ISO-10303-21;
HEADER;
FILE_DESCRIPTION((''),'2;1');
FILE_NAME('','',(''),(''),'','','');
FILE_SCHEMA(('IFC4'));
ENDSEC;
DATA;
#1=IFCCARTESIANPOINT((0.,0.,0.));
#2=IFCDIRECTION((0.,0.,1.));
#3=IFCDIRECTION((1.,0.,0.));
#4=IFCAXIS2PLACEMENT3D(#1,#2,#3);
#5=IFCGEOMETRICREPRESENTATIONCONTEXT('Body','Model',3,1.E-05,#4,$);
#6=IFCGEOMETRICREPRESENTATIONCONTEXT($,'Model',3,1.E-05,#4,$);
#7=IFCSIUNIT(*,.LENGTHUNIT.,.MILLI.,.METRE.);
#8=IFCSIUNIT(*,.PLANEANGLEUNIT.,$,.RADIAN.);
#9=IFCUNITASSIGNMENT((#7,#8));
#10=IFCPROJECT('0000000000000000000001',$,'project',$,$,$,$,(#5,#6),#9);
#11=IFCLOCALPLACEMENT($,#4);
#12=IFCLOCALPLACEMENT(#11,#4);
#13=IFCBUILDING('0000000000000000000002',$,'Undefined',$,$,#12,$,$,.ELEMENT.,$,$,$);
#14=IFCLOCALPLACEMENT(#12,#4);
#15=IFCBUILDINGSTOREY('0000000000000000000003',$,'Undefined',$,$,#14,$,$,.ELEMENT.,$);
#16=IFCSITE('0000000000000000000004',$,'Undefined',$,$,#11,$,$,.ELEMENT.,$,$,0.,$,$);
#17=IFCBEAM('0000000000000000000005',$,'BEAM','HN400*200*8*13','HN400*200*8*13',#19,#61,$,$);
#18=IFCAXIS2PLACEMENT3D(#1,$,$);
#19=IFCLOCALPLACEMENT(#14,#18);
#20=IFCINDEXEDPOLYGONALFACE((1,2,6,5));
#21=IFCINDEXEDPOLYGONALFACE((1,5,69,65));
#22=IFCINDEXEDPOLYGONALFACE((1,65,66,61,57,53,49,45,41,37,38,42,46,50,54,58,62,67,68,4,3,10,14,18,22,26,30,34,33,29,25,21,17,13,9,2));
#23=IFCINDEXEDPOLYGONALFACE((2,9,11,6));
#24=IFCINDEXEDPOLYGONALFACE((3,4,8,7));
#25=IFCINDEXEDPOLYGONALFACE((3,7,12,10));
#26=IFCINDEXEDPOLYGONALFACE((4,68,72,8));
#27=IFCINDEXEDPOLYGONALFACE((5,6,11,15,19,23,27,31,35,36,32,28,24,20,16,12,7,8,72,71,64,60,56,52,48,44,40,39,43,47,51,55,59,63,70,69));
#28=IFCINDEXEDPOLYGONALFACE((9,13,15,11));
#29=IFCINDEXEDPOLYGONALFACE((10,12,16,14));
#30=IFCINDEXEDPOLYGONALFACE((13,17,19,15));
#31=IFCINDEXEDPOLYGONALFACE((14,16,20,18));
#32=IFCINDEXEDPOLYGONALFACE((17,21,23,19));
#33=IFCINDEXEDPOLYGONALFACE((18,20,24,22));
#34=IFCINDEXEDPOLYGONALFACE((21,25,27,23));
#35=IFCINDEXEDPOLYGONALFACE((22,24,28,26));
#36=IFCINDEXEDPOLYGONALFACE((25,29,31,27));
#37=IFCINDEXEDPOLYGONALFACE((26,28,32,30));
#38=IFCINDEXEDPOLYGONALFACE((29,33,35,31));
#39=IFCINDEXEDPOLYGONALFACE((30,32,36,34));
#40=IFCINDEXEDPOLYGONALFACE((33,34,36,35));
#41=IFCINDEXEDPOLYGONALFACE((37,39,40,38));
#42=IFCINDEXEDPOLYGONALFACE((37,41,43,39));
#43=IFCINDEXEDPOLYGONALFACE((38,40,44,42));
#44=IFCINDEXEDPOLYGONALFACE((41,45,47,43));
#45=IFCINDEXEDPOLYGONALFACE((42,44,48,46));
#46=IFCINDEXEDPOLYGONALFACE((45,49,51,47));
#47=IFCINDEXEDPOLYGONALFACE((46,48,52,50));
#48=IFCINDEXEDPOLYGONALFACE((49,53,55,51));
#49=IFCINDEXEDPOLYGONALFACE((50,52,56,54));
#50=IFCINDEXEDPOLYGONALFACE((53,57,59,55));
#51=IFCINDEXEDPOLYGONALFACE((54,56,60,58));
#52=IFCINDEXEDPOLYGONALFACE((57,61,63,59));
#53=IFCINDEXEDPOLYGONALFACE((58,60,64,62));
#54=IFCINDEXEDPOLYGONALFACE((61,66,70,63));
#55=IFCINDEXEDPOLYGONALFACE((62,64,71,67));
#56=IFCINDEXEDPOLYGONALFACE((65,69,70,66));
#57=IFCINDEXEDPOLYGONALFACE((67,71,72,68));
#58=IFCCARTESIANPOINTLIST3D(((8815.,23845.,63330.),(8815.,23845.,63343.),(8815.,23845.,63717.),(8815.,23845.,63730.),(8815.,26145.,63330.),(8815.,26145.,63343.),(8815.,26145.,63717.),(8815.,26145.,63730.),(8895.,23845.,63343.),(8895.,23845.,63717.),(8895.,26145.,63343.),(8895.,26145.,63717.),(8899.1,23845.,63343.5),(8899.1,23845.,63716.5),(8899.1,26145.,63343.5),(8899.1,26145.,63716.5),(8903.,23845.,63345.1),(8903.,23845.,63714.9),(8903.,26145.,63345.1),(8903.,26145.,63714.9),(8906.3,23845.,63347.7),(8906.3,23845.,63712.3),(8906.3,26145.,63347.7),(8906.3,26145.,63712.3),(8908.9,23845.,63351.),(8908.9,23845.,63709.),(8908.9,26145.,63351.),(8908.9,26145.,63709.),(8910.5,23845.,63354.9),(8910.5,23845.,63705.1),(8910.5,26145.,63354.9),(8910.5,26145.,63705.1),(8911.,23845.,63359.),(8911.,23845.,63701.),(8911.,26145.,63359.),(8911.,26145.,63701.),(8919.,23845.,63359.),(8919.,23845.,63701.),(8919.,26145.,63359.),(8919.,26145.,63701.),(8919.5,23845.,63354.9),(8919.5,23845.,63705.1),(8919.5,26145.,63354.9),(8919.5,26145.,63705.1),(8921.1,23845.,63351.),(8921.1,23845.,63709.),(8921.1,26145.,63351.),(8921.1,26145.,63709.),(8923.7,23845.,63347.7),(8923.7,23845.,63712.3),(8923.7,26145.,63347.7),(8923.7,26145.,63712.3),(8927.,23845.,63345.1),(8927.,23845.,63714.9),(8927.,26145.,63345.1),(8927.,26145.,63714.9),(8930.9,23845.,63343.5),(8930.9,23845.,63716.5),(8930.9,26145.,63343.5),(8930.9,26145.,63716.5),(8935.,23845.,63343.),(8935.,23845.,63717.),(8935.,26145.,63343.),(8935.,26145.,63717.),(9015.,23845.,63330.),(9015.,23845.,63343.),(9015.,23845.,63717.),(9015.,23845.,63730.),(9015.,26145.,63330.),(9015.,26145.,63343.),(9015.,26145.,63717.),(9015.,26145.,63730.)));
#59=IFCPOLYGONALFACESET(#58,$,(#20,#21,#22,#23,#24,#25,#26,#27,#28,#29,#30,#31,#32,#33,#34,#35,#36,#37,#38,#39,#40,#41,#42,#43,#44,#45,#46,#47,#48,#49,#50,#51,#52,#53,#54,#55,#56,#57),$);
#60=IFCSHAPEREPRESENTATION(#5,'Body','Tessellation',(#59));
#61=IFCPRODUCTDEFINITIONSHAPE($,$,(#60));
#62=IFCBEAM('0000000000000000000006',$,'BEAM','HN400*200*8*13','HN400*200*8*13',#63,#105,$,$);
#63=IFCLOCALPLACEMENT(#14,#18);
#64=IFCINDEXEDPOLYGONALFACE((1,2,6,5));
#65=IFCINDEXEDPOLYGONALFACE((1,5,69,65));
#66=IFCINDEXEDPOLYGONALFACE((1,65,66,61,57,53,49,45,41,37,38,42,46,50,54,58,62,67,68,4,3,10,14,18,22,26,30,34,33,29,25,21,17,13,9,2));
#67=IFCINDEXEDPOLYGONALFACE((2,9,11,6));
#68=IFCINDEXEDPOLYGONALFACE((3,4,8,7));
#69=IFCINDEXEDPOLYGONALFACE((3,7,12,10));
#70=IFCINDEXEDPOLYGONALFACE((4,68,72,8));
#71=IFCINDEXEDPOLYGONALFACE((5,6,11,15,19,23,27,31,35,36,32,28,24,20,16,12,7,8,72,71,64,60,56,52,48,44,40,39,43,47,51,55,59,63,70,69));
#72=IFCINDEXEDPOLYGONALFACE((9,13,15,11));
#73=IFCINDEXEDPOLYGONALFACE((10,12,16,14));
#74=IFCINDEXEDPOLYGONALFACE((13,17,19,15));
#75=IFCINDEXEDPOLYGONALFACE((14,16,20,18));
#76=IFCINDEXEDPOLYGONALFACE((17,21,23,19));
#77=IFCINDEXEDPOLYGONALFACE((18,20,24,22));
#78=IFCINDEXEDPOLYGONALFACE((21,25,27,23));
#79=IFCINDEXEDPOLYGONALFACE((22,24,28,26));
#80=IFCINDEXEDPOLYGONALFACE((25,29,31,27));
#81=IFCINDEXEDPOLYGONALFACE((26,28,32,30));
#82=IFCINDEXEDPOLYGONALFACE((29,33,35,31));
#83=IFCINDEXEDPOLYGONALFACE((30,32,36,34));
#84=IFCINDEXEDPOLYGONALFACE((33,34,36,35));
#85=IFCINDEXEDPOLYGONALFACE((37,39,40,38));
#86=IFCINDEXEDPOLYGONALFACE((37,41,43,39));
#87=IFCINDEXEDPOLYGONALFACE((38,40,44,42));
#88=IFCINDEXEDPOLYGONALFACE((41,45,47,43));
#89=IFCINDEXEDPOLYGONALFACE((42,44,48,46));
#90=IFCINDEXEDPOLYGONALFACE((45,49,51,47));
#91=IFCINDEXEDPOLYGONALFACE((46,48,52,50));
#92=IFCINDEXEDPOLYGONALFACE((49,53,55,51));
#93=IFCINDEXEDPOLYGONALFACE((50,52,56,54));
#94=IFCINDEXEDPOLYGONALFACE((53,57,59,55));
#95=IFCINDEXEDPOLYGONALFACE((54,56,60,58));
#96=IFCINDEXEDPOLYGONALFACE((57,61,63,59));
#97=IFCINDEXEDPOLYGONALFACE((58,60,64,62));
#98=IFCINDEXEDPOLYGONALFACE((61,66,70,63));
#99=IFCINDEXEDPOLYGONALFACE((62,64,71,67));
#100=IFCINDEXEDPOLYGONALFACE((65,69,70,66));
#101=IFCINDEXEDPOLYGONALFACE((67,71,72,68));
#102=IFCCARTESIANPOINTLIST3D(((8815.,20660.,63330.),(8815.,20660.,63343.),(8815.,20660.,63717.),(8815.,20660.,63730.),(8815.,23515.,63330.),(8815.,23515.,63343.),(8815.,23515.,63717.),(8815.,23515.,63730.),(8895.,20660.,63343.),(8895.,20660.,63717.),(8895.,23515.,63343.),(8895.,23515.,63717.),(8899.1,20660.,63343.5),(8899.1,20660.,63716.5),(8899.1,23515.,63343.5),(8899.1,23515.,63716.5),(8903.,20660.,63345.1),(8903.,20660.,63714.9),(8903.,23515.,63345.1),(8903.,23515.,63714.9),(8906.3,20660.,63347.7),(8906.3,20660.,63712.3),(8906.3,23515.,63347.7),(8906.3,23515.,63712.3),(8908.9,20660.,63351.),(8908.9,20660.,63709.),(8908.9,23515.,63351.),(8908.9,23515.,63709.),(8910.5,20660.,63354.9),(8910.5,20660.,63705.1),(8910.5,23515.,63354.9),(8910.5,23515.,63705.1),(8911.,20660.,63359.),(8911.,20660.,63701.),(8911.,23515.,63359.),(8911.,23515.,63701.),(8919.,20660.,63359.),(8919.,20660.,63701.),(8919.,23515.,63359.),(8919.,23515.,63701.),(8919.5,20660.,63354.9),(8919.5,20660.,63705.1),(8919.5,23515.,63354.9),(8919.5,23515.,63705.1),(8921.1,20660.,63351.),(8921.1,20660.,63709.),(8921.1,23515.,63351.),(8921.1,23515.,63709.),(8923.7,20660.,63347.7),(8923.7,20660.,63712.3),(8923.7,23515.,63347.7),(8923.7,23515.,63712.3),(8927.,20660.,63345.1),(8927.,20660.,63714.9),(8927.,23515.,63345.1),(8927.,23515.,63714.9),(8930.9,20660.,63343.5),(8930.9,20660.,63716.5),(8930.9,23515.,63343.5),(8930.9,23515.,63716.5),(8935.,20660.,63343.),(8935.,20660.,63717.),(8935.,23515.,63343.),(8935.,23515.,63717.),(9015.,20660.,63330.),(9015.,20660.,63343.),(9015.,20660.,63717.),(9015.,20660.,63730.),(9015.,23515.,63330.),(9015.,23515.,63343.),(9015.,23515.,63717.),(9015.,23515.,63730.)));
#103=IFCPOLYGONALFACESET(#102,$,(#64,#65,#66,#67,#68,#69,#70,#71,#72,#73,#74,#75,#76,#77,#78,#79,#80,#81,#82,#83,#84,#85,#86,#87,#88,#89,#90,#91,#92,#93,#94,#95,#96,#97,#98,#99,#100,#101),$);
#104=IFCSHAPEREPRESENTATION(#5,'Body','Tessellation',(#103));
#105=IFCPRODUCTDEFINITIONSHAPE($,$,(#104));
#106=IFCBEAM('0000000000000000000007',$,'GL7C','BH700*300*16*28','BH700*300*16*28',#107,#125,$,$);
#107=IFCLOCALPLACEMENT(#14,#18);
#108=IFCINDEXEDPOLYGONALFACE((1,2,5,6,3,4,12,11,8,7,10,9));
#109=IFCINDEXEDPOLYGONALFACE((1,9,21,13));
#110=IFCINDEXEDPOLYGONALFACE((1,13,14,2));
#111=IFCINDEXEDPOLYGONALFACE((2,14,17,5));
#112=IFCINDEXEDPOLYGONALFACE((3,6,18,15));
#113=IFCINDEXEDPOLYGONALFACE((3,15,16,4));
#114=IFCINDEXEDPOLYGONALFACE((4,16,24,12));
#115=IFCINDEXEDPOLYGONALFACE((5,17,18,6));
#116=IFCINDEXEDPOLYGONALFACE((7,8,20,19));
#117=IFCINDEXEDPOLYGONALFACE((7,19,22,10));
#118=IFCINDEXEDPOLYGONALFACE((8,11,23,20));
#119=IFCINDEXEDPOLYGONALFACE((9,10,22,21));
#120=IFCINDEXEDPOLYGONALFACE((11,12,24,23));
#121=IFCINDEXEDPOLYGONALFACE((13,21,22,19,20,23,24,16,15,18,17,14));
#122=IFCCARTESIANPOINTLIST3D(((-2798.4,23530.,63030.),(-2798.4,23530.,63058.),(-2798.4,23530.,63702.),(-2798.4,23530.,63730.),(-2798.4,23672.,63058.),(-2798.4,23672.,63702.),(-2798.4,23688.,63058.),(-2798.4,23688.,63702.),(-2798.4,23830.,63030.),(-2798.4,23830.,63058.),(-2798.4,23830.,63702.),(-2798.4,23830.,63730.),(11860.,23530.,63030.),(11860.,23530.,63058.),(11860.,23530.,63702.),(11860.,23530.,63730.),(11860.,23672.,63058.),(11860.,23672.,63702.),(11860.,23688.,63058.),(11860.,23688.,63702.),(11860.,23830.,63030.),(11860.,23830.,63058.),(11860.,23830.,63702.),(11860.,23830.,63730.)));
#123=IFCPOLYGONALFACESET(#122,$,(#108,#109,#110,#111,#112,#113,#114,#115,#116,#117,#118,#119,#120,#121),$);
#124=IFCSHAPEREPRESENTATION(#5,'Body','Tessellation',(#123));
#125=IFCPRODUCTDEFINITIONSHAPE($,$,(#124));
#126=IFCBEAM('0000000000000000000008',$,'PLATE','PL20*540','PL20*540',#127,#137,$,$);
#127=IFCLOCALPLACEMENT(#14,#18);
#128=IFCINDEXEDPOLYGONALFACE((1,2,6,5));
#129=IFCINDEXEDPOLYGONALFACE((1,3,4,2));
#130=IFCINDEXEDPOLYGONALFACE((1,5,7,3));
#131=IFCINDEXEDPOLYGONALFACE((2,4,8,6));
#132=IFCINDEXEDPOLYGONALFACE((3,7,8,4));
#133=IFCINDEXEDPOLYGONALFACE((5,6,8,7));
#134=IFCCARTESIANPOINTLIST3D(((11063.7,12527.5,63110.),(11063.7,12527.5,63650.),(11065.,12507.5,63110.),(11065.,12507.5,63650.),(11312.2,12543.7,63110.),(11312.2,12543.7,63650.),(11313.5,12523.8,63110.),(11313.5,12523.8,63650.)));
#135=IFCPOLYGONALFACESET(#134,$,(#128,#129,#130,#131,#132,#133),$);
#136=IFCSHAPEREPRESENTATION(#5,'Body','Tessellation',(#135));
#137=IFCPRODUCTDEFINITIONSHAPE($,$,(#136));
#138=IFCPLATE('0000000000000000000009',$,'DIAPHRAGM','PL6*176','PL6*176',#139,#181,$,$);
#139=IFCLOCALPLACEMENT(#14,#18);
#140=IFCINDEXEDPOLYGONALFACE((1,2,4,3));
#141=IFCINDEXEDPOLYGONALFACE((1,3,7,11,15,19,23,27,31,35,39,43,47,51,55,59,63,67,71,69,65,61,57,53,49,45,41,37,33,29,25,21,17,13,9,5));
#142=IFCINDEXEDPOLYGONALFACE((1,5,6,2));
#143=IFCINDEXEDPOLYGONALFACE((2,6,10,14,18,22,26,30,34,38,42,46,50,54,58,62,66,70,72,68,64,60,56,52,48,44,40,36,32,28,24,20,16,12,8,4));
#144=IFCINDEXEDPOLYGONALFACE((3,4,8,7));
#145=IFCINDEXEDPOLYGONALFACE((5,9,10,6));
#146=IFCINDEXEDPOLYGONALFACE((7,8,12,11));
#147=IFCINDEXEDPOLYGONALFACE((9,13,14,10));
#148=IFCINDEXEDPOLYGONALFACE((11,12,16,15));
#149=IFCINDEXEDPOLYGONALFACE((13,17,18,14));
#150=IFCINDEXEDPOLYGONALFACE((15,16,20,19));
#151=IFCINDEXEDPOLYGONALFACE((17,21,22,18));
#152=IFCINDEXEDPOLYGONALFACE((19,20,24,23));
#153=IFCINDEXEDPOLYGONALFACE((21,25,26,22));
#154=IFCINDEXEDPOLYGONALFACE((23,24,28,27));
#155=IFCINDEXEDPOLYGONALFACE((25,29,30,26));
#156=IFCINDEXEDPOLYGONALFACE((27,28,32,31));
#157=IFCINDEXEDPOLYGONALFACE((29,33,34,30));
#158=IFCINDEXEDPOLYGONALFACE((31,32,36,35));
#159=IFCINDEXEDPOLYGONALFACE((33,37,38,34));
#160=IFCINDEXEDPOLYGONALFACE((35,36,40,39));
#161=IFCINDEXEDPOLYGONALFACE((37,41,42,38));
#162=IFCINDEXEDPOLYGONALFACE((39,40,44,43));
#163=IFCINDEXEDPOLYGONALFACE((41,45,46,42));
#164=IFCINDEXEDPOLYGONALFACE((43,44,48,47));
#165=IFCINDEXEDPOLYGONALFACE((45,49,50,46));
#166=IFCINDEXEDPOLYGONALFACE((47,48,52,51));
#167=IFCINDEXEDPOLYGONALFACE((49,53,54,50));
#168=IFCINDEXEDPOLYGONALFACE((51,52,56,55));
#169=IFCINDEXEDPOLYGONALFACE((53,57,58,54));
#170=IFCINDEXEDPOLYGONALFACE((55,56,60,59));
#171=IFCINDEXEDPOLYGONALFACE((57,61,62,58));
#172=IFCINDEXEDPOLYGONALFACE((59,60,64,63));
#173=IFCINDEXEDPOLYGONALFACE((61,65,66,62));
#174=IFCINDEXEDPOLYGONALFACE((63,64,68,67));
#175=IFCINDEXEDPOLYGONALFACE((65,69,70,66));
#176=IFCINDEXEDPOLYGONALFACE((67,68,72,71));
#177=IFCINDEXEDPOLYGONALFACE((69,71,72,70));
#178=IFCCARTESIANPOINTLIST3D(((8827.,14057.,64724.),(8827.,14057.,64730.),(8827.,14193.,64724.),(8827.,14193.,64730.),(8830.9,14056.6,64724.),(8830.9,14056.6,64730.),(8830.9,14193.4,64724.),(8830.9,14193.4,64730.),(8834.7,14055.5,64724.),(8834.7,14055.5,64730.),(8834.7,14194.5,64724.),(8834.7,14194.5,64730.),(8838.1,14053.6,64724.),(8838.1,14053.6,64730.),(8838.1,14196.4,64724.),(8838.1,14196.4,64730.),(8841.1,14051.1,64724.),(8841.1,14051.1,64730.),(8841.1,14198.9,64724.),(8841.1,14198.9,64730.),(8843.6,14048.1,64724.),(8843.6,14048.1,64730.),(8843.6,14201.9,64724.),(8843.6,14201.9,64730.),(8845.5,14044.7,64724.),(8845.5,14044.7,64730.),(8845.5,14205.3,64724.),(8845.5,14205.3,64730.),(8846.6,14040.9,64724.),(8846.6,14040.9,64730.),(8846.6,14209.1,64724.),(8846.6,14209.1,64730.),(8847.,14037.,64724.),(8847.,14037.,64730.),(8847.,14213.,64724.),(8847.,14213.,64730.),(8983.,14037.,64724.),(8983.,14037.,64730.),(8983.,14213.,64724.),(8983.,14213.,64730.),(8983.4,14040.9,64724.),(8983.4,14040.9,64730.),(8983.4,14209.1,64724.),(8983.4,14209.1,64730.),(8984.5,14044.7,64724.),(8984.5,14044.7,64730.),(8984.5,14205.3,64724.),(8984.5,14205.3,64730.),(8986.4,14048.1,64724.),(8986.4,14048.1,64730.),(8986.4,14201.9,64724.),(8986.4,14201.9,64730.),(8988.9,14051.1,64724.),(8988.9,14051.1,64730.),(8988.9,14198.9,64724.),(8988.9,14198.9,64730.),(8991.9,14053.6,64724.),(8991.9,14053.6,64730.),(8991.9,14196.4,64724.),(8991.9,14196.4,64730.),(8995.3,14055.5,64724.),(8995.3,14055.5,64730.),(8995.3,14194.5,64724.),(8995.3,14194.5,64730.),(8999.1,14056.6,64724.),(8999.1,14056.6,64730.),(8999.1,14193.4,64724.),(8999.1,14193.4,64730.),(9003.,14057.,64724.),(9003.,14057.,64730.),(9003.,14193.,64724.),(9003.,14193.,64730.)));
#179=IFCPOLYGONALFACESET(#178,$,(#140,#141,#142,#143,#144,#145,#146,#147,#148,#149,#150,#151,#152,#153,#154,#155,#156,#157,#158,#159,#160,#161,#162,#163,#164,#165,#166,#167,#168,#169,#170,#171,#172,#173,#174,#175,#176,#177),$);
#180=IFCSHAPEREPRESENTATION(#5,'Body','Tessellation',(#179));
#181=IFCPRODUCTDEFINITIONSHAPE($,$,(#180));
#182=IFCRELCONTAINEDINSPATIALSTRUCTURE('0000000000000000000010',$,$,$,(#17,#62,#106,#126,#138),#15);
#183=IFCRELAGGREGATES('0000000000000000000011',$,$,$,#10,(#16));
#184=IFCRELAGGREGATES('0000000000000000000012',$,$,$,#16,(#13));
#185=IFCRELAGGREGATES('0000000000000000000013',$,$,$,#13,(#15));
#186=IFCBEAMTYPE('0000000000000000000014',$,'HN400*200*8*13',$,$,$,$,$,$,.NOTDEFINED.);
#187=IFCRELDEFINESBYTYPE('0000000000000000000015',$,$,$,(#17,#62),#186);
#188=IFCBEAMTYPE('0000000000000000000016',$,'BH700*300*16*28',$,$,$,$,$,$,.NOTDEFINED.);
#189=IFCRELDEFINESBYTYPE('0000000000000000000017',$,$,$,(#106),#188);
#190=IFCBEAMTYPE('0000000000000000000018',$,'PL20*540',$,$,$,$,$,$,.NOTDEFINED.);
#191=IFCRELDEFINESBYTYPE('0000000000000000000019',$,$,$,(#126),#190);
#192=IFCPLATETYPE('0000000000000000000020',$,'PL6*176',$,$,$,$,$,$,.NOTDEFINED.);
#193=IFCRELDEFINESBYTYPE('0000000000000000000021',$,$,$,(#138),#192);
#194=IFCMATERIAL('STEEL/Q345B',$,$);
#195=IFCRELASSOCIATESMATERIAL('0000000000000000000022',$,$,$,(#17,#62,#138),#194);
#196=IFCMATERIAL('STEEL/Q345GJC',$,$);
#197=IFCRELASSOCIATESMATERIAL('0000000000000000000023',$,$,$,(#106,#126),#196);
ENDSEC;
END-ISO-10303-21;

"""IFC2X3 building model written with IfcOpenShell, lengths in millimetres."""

from ifc_helpers import new_model, si_unit, frame, origin_with_axes, origin_2d_with_axis, place, context, project, spatial, polyline, rectangle, i_section, outline, extrude, material, type_object, element, save


model = new_model("IFC2X3")

# Units and contexts
model_context_1 = context("Model", 3, precision=1e-05, world=origin_with_axes(), identifier="Body")
model_context_2 = context("Model", 3, precision=1e-05, world=origin_with_axes())
ifc_project = project(units=[si_unit("LENGTHUNIT", "METRE", prefix="MILLI"), si_unit("PLANEANGLEUNIT", "RADIAN")], contexts=[model_context_1, model_context_2])

# Site, building, storey
site_placement = place(None, origin_with_axes())
site = spatial("IfcSite", under=ifc_project, at=site_placement, Name="Undefined", CompositionType="ELEMENT", RefElevation=0.0)
building_placement = place(site_placement, origin_with_axes())
building = spatial("IfcBuilding", under=site, at=building_placement, Name="Undefined", CompositionType="ELEMENT")
storey_placement = place(building_placement, origin_with_axes())
storey = spatial("IfcBuildingStorey", under=building, at=storey_placement, Name="Undefined", CompositionType="ELEMENT")

# Shared definitions
ifc_material_1 = material(Name="STEEL/Q345B")

# Beams
beam_type_1 = type_object("IfcBeamType", Name="HN400*200*8*13", PredefinedType="NOTDEFINED")
beam_1_placement = place(storey_placement, frame((8915.0, 23680.0, 63530.0), z_axis=(0.0, 0.0, 1.0), x_axis=(0.0, 1.0, 0.0)))
element("IfcBeam", 1, at=beam_1_placement, inside=storey, type_object=beam_type_1, material=ifc_material_1, Name="BEAM", Description="HN400*200*8*13", ObjectType="HN400*200*8*13", context=model_context_1, shape_type="SweptSolid", body=[
    extrude(i_section(OverallWidth=200.0, OverallDepth=400.0, WebThickness=8.0, FlangeThickness=13.0, FilletRadius=16.0, at=origin_2d_with_axis()), frame((2465.0, 0.0, 0.0), z_axis=(-1.0, 0.0, 0.0), x_axis=(0.0, -1.0, 0.0)), (0.0, 0.0, 1.0), 2300.0),
])
beam_2_placement = place(storey_placement, frame((8915.0, 20495.0, 63530.0), z_axis=(0.0, 0.0, 1.0), x_axis=(0.0, 1.0, 0.0)))
element("IfcBeam", 2, at=beam_2_placement, inside=storey, type_object=beam_type_1, material=ifc_material_1, Name="BEAM", Description="HN400*200*8*13", ObjectType="HN400*200*8*13", context=model_context_1, shape_type="SweptSolid", body=[
    extrude(i_section(OverallWidth=200.0, OverallDepth=400.0, WebThickness=8.0, FlangeThickness=13.0, FilletRadius=16.0, at=origin_2d_with_axis()), frame((3020.0, 0.0, 0.0), z_axis=(-1.0, 0.0, 0.0), x_axis=(0.0, -1.0, 0.0)), (0.0, 0.0, 1.0), 2855.0),
])
ifc_material_2 = material(Name="STEEL/Q345GJC")
beam_type_2 = type_object("IfcBeamType", Name="BH700*300*16*28", PredefinedType="NOTDEFINED")
beam_3_placement = place(storey_placement, frame((11880.0, 23680.0, 63380.0), z_axis=(0.0, 0.0, 1.0), x_axis=(-1.0, 0.0, 0.0)))
element("IfcBeam", 3, at=beam_3_placement, inside=storey, type_object=beam_type_2, material=ifc_material_2, Name="GL7C", Description="BH700*300*16*28", ObjectType="BH700*300*16*28", context=model_context_1, shape_type="SweptSolid", body=[
    extrude(i_section(OverallWidth=300.0, OverallDepth=700.0, WebThickness=16.0, FlangeThickness=28.0, at=origin_2d_with_axis()), frame((14678.4, 0.0, 0.0), z_axis=(-1.0, 0.0, 0.0), x_axis=(0.0, -1.0, 0.0)), (0.0, 0.0, 1.0), 14658.4),
])
beam_type_3 = type_object("IfcBeamType", Name="PL20*540", PredefinedType="NOTDEFINED")
beam_4_placement = place(storey_placement, frame((11312.8, 12533.7, 63380.0), z_axis=(0.0, 0.0, 1.0), x_axis=(-0.997873, -0.065183, 0.0)))
element("IfcBeam", 4, at=beam_4_placement, inside=storey, type_object=beam_type_3, material=ifc_material_2, Name="PLATE", Description="PL20*540", ObjectType="PL20*540", context=model_context_1, shape_type="SweptSolid", body=[
    extrude(rectangle(XDim=20.0, YDim=540.0, at=origin_2d_with_axis()), frame((249.0, 0.0, 0.0), z_axis=(-1.0, 0.0, 0.0), x_axis=(0.0, -1.0, 0.0)), (0.0, 0.0, 1.0), 249.0),
])

# Plate
plate_type_1 = type_object("IfcPlateType", Name="PL6*176", PredefinedType="NOTDEFINED")
for number, where, z_axis, x_axis, name in (
    (5, (9003.0, 14037.0, 64727.0), (0.0, 0.0, -1.0), (-1.0, 0.0, 0.0), "DIAPHRAGM"),
):
    element("IfcPlate", number, at=place(storey_placement, frame(where, z_axis=z_axis, x_axis=x_axis)), inside=storey, type_object=plate_type_1, material=ifc_material_1, Name=name, Description="PL6*176", ObjectType="PL6*176", context=model_context_1, shape_type="SweptSolid", body=[
        extrude(outline(polyline([(0.0, 20.0), (3.9, 19.6), (7.7, 18.5), (11.1, 16.6), (14.1, 14.1), (16.6, 11.1), (18.5, 7.7), (19.6, 3.9), (20.0, 0.0), (156.0, 0.0), (156.4, 3.9), (157.5, 7.7), (159.4, 11.1), (161.9, 14.1), (164.9, 16.6), (168.3, 18.5), (172.1, 19.6), (176.0, 20.0), (176.0, 156.0), (172.1, 156.4), (168.3, 157.5), (164.9, 159.4), (161.9, 161.9), (159.4, 164.9), (157.5, 168.3), (156.4, 172.1), (156.0, 176.0), (20.0, 176.0), (19.6, 172.1), (18.5, 168.3), (16.6, 164.9), (14.1, 161.9), (11.1, 159.4), (7.7, 157.5), (3.9, 156.4), (0.0, 156.0), (0.0, 20.0)])), frame((0.0, 0.0, -3.0), z_axis=(0.0, 0.0, 1.0), x_axis=(1.0, 0.0, 0.0)), (0.0, 0.0, 1.0), 6.0),
    ])

save(model, "model.ifc")
